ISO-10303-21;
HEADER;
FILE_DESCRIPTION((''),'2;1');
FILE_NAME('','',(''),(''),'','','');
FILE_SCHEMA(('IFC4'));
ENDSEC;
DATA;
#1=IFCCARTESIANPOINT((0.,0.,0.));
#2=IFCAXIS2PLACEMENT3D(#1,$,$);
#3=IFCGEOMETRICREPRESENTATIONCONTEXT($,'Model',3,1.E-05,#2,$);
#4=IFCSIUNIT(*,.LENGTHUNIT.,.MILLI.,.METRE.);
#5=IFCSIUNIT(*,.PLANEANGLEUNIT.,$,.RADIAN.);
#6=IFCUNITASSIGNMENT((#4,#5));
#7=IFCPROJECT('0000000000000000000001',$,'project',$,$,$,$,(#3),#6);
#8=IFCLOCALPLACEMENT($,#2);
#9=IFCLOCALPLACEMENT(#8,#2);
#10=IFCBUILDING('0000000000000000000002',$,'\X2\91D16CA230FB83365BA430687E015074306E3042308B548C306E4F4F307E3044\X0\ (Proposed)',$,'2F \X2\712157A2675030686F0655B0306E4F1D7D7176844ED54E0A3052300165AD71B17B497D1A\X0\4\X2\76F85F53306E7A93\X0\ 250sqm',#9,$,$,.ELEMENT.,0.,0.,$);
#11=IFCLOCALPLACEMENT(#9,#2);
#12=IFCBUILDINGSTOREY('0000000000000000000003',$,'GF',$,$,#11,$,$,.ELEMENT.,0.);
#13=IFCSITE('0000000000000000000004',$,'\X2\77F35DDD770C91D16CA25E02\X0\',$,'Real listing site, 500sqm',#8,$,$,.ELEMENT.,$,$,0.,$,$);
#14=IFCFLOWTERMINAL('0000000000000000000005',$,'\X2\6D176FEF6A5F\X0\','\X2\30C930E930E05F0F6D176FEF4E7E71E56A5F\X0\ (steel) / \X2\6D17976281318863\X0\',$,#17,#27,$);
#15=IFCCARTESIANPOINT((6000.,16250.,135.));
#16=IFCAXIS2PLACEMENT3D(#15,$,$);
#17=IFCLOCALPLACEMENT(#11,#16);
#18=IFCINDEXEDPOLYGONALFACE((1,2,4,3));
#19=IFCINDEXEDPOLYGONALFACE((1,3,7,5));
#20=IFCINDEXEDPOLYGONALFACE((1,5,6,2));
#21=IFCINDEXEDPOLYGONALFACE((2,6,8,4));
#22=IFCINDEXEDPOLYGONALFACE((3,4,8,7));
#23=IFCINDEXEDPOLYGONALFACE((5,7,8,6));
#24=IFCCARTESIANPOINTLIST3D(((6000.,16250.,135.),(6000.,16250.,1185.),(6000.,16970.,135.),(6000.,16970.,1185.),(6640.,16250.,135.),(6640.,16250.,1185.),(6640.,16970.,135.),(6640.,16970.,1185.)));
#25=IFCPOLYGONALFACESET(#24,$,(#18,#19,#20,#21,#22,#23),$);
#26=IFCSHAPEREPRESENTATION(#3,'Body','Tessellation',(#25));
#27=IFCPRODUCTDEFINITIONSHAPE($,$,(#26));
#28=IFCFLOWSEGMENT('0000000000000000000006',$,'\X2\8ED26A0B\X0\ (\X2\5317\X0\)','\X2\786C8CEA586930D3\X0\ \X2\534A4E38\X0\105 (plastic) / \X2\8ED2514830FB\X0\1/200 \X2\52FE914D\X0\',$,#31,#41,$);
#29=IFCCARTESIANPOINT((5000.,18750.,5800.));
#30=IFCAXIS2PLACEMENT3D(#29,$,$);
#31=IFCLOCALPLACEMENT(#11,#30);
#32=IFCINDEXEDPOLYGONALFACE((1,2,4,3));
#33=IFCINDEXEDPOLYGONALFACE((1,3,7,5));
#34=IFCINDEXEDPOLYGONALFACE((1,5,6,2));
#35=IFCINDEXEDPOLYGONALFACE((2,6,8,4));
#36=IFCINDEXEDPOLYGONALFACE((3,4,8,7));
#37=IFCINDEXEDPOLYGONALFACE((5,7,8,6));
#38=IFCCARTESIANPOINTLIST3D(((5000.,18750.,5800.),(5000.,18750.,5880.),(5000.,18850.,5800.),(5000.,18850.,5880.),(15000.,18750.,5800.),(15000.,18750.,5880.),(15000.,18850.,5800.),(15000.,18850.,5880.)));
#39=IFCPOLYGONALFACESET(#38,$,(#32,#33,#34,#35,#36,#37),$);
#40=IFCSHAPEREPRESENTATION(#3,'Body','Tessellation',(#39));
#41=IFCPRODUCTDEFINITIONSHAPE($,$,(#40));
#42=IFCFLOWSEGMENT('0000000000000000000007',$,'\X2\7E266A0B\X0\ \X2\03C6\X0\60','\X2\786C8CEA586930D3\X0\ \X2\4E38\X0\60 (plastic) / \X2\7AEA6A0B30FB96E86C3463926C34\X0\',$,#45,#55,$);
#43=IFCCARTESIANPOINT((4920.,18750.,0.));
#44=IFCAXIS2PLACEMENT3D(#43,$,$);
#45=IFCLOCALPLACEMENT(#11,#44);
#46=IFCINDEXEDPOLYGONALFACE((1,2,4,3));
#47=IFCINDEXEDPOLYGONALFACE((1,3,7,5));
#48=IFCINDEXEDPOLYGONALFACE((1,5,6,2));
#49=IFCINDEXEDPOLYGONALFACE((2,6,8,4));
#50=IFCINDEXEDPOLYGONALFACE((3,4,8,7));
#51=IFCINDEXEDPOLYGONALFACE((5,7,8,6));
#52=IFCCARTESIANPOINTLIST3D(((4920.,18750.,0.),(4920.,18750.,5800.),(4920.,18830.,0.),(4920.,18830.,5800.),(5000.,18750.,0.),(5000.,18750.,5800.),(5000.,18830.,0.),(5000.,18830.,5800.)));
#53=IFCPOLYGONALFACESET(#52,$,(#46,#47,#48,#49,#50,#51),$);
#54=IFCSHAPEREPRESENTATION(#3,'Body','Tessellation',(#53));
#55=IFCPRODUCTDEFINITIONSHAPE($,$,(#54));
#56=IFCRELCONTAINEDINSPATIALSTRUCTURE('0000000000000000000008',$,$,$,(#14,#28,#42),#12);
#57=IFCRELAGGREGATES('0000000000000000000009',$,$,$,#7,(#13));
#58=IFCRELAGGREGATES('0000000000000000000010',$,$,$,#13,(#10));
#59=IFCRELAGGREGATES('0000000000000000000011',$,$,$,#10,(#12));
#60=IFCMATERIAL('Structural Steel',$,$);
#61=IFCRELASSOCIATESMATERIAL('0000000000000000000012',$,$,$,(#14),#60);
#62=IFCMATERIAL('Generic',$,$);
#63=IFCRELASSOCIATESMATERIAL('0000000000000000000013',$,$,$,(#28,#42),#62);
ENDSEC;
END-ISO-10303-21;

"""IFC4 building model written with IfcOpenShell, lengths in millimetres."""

from ifc_helpers import new_model, si_unit, frame, frame_2d, origin, place, context, project, spatial, rectangle, extrude, material, element, save


model = new_model("IFC4")

# Units and contexts
model_context = context("Model", 3, precision=1e-05, world=origin())
ifc_project = project(units=[si_unit("LENGTHUNIT", "METRE", prefix="MILLI"), si_unit("PLANEANGLEUNIT", "RADIAN")], contexts=[model_context])

# Site, building, storey
site_placement = place(None, origin())
site = spatial("IfcSite", under=ifc_project, at=site_placement, Name="石川県金沢市", ObjectType="Real listing site, 500sqm", CompositionType="ELEMENT", RefElevation=0.0)
building_placement = place(site_placement, origin())
building = spatial("IfcBuilding", under=site, at=building_placement, Name="金沢・茶室と縁側のある和の住まい (Proposed)", ObjectType="2F 無垢材と漆喰の伝統的仕上げ、断熱等級4相当の窓 250sqm", CompositionType="ELEMENT", ElevationOfRefHeight=0.0, ElevationOfTerrain=0.0)
storey_placement = place(building_placement, origin())
storey = spatial("IfcBuildingStorey", under=building, at=storey_placement, Name="GF", CompositionType="ELEMENT", Elevation=0.0)

# Flow terminal
ifc_material_1 = material(Name="Structural Steel")
flow_terminal_placement = place(storey_placement, frame((6000.0, 16250.0, 135.0)))
element("IfcFlowTerminal", 1, at=flow_terminal_placement, inside=storey, material=ifc_material_1, Name="洗濯機", Description="ドラム式洗濯乾燥機 (steel) / 洗面脱衣", context=model_context, shape_type="SweptSolid", body=[
    extrude(rectangle(XDim=640.0, YDim=720.0, at=frame_2d((320.0, 360.0))), frame((6000.0, 16250.0, 135.0)), (0.0, 0.0, 1.0), 1050.0),
])

# Flow segments
ifc_material_2 = material(Name="Generic")
flow_segment_1_placement = place(storey_placement, frame((5000.0, 18750.0, 5800.0)))
element("IfcFlowSegment", 2, at=flow_segment_1_placement, inside=storey, material=ifc_material_2, Name="軒樋 (北)", Description="硬質塩ビ 半丸105 (plastic) / 軒先・1/200 勾配", context=model_context, shape_type="SweptSolid", body=[
    extrude(rectangle(XDim=10000.0, YDim=100.0, at=frame_2d((5000.0, 50.0))), frame((5000.0, 18750.0, 5800.0)), (0.0, 0.0, 1.0), 80.0),
])
flow_segment_2_placement = place(storey_placement, frame((4920.0, 18750.0, 0.0)))
element("IfcFlowSegment", 3, at=flow_segment_2_placement, inside=storey, material=ifc_material_2, Name="縦樋 φ60", Description="硬質塩ビ 丸60 (plastic) / 竪樋・雨水排水", context=model_context, shape_type="SweptSolid", body=[
    extrude(rectangle(XDim=80.0, YDim=80.0, at=frame_2d((40.0, 40.0))), frame((4920.0, 18750.0, 0.0)), (0.0, 0.0, 1.0), 5800.0),
])

save(model, "model.ifc")
